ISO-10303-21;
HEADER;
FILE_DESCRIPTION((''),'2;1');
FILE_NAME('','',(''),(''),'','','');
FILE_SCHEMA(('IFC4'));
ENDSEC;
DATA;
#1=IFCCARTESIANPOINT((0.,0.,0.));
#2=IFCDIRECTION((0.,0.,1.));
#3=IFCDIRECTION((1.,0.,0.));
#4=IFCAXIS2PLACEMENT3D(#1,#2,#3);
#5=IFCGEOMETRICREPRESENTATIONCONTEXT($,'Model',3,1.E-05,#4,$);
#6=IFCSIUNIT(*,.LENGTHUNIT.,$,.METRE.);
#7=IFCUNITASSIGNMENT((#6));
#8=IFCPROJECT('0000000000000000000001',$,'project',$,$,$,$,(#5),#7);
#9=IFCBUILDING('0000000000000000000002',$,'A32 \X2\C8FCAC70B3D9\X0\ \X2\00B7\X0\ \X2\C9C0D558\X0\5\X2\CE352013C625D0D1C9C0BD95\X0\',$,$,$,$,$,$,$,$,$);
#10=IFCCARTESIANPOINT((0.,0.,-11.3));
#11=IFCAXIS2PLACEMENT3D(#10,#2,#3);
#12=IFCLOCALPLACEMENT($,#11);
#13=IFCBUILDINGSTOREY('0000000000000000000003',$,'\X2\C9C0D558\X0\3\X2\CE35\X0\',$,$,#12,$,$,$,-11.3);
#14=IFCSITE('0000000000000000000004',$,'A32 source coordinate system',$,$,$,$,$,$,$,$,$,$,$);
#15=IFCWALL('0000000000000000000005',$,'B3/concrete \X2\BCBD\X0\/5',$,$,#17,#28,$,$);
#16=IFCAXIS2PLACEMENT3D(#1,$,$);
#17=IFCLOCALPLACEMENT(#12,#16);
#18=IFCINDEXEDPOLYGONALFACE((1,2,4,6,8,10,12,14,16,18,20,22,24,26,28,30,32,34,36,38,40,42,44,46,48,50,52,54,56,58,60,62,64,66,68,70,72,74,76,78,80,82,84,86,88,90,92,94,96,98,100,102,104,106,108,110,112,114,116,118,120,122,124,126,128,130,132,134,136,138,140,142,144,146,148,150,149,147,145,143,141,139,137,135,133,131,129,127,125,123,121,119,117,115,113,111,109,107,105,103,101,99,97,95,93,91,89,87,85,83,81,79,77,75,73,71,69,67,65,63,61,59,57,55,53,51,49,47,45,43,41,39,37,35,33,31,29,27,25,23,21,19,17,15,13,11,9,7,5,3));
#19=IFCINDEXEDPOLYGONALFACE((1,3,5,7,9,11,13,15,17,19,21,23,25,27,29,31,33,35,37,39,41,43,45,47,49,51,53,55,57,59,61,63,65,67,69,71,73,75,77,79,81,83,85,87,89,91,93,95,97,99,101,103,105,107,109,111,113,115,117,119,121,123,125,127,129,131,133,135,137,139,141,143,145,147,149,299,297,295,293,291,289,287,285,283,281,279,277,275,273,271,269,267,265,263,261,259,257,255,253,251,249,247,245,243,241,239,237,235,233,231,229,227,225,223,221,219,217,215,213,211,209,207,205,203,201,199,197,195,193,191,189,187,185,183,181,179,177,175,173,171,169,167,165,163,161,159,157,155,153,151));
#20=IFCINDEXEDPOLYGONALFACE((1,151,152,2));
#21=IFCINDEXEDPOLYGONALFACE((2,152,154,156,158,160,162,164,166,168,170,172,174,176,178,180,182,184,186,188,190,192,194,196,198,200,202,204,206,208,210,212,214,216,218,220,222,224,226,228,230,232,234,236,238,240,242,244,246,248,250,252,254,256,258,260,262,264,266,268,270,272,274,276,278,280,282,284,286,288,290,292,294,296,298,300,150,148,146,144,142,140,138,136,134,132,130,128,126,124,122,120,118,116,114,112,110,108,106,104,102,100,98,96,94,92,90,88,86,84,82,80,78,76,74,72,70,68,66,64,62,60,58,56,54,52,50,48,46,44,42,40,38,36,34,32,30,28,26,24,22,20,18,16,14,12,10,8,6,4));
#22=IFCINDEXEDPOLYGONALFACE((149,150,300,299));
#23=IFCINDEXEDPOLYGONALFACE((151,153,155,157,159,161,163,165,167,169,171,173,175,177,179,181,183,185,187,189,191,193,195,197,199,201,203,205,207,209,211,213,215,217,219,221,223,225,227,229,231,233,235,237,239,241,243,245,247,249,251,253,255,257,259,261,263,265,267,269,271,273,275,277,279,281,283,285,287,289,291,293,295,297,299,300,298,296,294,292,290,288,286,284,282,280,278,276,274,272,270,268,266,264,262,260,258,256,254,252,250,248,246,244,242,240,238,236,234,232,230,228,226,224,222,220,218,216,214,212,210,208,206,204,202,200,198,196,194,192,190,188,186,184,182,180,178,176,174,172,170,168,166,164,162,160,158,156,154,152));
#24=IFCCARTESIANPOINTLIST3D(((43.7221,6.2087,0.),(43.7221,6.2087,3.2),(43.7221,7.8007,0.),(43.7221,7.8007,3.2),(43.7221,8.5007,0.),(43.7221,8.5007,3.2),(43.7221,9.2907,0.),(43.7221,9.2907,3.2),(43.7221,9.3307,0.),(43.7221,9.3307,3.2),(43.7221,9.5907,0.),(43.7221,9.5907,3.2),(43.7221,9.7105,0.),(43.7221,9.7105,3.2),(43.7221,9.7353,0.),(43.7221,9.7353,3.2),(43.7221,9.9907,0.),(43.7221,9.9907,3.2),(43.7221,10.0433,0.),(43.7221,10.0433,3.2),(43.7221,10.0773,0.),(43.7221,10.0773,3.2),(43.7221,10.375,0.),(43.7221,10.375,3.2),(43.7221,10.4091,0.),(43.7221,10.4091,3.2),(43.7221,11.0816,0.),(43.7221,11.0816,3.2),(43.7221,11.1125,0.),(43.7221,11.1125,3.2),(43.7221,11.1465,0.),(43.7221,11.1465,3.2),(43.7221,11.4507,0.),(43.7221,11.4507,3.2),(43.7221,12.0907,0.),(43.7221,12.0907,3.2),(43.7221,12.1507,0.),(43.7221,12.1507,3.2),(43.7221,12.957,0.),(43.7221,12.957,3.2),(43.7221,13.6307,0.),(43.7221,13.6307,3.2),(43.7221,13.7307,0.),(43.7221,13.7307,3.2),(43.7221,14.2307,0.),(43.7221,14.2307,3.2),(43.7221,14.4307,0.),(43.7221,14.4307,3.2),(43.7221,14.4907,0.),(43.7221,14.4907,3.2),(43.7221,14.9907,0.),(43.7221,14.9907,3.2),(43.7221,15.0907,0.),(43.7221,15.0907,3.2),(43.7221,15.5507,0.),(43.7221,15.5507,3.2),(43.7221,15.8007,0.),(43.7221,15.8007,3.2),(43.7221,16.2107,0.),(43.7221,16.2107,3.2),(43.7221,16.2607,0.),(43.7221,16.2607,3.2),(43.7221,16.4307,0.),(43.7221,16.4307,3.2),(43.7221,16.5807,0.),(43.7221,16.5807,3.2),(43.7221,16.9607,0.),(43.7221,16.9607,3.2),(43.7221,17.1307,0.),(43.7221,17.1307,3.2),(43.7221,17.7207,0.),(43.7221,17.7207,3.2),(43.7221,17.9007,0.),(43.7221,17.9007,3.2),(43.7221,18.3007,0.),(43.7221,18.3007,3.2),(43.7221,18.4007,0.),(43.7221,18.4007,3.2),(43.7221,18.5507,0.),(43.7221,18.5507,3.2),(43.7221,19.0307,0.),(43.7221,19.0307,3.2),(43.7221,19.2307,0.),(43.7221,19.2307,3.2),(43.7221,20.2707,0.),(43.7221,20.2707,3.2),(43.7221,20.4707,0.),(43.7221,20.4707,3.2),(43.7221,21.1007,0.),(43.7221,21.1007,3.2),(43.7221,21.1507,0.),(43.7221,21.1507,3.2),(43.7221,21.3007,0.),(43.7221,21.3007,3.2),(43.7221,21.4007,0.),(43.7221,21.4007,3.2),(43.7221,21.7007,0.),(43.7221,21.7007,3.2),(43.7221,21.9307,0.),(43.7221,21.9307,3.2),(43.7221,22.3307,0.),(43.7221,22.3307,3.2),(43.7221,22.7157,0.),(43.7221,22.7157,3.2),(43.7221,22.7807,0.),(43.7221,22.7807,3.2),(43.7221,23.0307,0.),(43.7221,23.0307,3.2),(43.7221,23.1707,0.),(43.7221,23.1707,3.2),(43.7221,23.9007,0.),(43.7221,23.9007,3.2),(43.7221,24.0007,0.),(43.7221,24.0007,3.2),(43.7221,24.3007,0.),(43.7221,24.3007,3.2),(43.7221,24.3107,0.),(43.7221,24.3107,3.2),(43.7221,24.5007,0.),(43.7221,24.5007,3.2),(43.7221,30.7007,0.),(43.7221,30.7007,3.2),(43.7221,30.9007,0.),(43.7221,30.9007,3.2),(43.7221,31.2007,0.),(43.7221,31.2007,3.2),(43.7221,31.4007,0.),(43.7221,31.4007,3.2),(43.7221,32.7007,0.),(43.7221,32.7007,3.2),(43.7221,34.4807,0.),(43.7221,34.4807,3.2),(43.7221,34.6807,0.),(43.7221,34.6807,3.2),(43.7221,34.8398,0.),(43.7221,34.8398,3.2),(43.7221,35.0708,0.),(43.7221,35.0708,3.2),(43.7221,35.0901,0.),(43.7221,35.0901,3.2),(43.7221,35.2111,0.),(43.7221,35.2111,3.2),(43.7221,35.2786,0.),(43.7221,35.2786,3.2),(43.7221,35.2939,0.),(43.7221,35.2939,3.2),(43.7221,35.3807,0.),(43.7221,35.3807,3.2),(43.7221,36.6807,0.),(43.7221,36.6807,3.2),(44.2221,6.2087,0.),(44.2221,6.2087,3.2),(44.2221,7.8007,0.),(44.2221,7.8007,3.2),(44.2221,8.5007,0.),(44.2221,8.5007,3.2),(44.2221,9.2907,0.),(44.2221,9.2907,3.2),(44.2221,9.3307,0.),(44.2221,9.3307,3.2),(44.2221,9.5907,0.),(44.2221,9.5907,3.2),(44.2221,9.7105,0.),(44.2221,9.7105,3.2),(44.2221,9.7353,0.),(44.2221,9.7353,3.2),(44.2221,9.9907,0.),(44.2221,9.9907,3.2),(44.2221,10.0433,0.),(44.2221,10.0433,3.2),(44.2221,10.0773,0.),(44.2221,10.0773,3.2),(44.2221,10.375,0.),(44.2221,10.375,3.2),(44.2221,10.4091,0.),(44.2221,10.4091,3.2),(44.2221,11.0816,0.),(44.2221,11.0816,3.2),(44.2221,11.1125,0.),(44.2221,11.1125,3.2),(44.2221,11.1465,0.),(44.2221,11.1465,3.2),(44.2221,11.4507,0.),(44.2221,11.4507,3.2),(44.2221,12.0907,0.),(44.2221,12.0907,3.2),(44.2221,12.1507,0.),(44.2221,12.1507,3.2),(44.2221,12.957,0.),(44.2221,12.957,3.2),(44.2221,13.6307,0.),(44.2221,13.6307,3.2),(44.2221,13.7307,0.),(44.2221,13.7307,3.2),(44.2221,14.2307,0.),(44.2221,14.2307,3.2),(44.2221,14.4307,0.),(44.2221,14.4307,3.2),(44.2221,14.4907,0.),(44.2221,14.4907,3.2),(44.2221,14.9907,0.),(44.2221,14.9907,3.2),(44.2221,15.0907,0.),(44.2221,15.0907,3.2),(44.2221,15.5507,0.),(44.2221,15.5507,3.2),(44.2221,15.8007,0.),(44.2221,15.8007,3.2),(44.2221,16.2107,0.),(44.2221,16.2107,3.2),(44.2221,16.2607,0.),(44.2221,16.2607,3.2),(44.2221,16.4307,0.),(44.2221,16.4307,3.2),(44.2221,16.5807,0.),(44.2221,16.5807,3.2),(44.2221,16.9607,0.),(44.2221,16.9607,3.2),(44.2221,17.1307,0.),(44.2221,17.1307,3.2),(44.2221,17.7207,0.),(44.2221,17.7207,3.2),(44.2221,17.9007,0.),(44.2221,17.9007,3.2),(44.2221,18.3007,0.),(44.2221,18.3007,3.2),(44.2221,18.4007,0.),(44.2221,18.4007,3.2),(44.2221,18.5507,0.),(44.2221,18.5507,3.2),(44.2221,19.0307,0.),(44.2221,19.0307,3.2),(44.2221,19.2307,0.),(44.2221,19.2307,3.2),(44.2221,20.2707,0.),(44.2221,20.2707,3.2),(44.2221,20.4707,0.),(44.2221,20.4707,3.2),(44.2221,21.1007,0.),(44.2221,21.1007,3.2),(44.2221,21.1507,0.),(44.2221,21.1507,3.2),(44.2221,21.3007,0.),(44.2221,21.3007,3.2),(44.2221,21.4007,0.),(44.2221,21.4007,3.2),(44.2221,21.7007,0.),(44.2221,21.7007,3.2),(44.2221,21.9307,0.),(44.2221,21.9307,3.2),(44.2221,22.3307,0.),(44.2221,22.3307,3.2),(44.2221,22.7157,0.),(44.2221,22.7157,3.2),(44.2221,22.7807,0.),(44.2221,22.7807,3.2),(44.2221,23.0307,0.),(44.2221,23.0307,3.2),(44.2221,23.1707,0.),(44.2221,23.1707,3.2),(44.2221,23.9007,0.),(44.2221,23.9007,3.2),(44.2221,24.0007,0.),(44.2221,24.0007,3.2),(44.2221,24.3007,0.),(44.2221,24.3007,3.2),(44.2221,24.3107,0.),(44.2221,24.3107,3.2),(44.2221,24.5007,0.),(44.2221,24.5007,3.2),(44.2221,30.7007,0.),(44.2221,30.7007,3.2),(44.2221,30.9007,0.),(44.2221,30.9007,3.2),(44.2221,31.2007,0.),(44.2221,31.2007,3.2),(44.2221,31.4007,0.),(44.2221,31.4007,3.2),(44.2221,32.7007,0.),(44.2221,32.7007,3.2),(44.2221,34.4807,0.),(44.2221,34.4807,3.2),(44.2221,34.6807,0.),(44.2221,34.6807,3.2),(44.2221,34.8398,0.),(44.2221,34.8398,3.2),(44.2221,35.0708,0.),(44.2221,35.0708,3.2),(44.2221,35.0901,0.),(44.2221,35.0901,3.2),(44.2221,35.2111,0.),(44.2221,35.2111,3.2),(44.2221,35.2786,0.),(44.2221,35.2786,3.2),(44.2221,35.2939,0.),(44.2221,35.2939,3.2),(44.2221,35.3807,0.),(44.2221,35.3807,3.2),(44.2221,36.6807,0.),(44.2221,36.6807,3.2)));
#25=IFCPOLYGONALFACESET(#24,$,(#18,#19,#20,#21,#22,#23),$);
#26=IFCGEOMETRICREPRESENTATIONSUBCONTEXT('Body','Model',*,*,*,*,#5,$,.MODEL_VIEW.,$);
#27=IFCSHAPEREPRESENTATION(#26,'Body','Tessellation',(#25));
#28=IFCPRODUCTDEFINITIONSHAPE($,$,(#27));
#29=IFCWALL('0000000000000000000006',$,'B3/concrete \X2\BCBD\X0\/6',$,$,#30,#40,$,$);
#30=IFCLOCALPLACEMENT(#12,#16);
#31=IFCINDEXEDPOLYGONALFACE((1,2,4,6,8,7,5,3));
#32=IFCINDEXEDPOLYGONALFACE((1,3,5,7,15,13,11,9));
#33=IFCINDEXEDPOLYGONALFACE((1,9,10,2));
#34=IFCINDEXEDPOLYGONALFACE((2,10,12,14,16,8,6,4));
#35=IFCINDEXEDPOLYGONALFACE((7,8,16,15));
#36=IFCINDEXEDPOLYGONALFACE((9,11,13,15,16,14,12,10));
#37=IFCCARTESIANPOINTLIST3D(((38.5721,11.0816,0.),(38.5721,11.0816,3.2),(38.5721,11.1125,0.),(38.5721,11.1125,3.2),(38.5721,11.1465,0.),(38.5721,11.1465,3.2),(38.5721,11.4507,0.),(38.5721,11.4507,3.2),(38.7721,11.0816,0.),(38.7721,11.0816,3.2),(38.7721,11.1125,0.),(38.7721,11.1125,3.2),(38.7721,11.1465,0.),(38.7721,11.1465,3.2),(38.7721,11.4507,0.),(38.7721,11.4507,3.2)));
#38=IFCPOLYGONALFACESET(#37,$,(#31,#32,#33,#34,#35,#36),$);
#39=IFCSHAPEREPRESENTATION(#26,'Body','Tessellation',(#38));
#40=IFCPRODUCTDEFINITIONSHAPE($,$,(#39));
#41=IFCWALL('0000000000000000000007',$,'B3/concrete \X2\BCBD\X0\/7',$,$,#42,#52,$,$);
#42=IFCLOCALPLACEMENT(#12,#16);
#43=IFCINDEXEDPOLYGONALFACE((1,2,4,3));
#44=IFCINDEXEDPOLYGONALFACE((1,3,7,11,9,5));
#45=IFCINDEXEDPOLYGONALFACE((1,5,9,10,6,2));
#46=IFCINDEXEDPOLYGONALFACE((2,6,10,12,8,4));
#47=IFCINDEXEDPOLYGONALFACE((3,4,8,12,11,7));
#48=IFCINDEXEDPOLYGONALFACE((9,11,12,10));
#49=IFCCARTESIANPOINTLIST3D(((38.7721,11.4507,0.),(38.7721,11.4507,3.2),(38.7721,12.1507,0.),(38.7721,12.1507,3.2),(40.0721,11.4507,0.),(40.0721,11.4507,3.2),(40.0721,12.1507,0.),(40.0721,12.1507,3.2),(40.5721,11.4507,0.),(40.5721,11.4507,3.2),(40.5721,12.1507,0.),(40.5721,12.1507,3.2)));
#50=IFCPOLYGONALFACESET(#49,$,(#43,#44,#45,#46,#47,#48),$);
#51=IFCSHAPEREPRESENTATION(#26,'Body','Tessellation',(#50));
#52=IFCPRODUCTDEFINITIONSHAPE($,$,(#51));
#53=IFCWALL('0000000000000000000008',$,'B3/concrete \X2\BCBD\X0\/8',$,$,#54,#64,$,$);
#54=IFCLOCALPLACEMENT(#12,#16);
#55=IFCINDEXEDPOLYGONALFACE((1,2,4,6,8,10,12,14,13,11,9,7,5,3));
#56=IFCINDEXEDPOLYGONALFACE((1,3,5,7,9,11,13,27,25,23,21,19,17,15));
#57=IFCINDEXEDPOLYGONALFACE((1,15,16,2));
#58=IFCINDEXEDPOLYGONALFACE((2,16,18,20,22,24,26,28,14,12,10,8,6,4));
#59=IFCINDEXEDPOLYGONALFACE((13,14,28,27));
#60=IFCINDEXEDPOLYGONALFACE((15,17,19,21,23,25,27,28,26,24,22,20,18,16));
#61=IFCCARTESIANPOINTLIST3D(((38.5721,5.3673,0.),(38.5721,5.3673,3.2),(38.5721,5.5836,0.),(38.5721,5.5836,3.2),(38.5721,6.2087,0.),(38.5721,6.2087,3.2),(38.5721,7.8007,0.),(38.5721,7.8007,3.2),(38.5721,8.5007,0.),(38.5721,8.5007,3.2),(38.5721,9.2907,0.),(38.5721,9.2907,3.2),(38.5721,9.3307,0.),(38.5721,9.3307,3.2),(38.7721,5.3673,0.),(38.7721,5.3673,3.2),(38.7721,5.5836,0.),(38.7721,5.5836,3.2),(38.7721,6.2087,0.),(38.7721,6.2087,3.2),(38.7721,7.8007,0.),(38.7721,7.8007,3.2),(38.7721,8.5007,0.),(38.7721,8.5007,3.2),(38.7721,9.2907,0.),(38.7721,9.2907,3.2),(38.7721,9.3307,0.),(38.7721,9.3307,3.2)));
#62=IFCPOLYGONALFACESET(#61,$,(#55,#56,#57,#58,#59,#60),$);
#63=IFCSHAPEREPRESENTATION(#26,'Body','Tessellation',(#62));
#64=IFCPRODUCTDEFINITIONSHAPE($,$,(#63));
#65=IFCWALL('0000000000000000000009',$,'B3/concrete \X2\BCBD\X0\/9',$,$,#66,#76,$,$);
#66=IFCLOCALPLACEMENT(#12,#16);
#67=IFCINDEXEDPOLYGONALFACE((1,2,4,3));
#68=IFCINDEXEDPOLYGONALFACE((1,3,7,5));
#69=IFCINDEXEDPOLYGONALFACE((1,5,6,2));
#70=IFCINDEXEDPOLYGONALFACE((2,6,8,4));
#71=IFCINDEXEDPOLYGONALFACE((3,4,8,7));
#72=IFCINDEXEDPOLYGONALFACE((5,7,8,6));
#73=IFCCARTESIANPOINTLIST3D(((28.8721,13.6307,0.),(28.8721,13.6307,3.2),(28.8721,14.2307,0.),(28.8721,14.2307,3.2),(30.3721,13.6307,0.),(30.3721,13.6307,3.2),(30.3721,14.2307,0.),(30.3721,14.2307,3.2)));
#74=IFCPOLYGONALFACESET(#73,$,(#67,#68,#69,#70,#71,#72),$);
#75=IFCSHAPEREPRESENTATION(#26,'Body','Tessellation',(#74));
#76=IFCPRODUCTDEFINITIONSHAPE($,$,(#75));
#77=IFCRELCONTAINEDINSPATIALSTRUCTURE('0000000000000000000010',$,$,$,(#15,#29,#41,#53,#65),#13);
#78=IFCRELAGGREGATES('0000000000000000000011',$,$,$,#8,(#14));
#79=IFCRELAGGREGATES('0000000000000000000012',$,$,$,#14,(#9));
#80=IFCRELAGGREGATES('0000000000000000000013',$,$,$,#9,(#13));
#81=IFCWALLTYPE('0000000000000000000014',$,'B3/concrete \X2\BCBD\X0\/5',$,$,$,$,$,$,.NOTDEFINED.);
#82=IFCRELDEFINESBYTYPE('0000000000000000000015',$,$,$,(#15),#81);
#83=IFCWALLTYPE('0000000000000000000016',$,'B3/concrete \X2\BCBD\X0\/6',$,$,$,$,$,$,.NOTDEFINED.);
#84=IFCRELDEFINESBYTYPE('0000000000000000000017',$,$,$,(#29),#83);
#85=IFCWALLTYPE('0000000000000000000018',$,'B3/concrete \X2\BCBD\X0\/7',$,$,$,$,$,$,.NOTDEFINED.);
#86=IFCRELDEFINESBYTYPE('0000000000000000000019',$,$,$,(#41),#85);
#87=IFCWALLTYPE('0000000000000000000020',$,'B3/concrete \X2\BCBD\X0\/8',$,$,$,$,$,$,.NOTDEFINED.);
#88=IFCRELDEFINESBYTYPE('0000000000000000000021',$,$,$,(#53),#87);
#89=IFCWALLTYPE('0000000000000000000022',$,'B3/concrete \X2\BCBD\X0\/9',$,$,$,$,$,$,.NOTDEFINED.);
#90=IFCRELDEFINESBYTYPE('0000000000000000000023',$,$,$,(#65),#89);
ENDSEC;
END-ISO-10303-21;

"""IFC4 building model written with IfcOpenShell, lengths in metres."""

from ifc_helpers import new_model, si_unit, frame, origin, origin_with_axes, place, context, subcontext, project, spatial, polyline, outline, extrude, source, transform, mapped, type_object, type_shapes, element, save


model = new_model("IFC4")

# Units and contexts
model_context = context("Model", 3, precision=1e-05, world=origin_with_axes())
body_context = subcontext(model_context, "Body", "Model", "MODEL_VIEW")
ifc_project = project(units=[si_unit("LENGTHUNIT", "METRE")], contexts=[model_context])

# Site, building, storey
site = spatial("IfcSite", under=ifc_project, Name="A32 source coordinate system")
building = spatial("IfcBuilding", under=site, Name="A32 주거동 · 지하5층–옥탑지붕")
storey_placement = place(None, frame((0.0, 0.0, -11.3), z_axis=(0.0, 0.0, 1.0), x_axis=(1.0, 0.0, 0.0)))
storey = spatial("IfcBuildingStorey", under=building, at=storey_placement, Name="지하3층", Elevation=-11.3)

# Walls
wall_type_1 = type_object("IfcWallType", Name="B3/concrete 벽/5", PredefinedType="NOTDEFINED")
shared_shape_1 = source(origin(), body_context, "Body", "SweptSolid", [
    extrude(outline(polyline([(44.2221, 35.2939), (44.2221, 35.2786), (44.2221, 35.2111), (44.2221, 35.0901), (44.2221, 35.0708), (44.2221, 34.8398), (44.2221, 34.6807), (44.2221, 34.4807), (44.2221, 32.7007), (44.2221, 31.4007), (44.2221, 31.2007), (44.2221, 30.9007), (44.2221, 30.7007), (44.2221, 24.5007), (44.2221, 24.3107), (44.2221, 24.3007), (44.2221, 24.0007), (44.2221, 23.9007), (44.2221, 23.1707), (44.2221, 23.0307), (44.2221, 22.7807), (44.2221, 22.7157), (44.2221, 22.3307), (44.2221, 21.9307), (44.2221, 21.7007), (44.2221, 21.4007), (44.2221, 21.3007), (44.2221, 21.1507), (44.2221, 21.1007), (44.2221, 20.4707), (44.2221, 20.2707), (44.2221, 19.2307), (44.2221, 19.0307), (44.2221, 18.5507), (44.2221, 18.4007), (44.2221, 18.3007), (44.2221, 17.9007), (44.2221, 17.7207), (44.2221, 17.1307), (44.2221, 16.9607), (44.2221, 16.5807), (44.2221, 16.4307), (44.2221, 16.2607), (44.2221, 16.2107), (44.2221, 15.8007), (44.2221, 15.5507), (44.2221, 15.0907), (44.2221, 14.9907), (44.2221, 14.4907), (44.2221, 14.4307), (44.2221, 14.2307), (44.2221, 13.7307), (44.2221, 13.6307), (44.2221, 12.957), (44.2221, 12.1507), (44.2221, 12.0907), (44.2221, 11.4507), (44.2221, 11.1465), (44.2221, 11.1125), (44.2221, 11.0816), (44.2221, 10.4091), (44.2221, 10.375), (44.2221, 10.0773), (44.2221, 10.0433), (44.2221, 9.9907), (44.2221, 9.7353), (44.2221, 9.7105), (44.2221, 9.5907), (44.2221, 9.3307), (44.2221, 9.2907), (44.2221, 8.5007), (44.2221, 7.8007), (44.2221, 6.2087), (43.7221, 6.2087), (43.7221, 7.8007), (43.7221, 8.5007), (43.7221, 9.2907), (43.7221, 9.3307), (43.7221, 9.5907), (43.7221, 9.7105), (43.7221, 9.7353), (43.7221, 9.9907), (43.7221, 10.0433), (43.7221, 10.0773), (43.7221, 10.375), (43.7221, 10.4091), (43.7221, 11.0816), (43.7221, 11.1125), (43.7221, 11.1465), (43.7221, 11.4507), (43.7221, 12.0907), (43.7221, 12.1507), (43.7221, 12.957), (43.7221, 13.6307), (43.7221, 13.7307), (43.7221, 14.2307), (43.7221, 14.4307), (43.7221, 14.4907), (43.7221, 14.9907), (43.7221, 15.0907), (43.7221, 15.5507), (43.7221, 15.8007), (43.7221, 16.2107), (43.7221, 16.2607), (43.7221, 16.4307), (43.7221, 16.5807), (43.7221, 16.9607), (43.7221, 17.1307), (43.7221, 17.7207), (43.7221, 17.9007), (43.7221, 18.3007), (43.7221, 18.4007), (43.7221, 18.5507), (43.7221, 19.0307), (43.7221, 19.2307), (43.7221, 20.2707), (43.7221, 20.4707), (43.7221, 21.1007), (43.7221, 21.1507), (43.7221, 21.3007), (43.7221, 21.4007), (43.7221, 21.7007), (43.7221, 21.9307), (43.7221, 22.3307), (43.7221, 22.7157), (43.7221, 22.7807), (43.7221, 23.0307), (43.7221, 23.1707), (43.7221, 23.9007), (43.7221, 24.0007), (43.7221, 24.3007), (43.7221, 24.3107), (43.7221, 24.5007), (43.7221, 30.7007), (43.7221, 30.9007), (43.7221, 31.2007), (43.7221, 31.4007), (43.7221, 32.7007), (43.7221, 34.4807), (43.7221, 34.6807), (43.7221, 34.8398), (43.7221, 35.0708), (43.7221, 35.0901), (43.7221, 35.2111), (43.7221, 35.2786), (43.7221, 35.2939), (43.7221, 35.3807), (43.7221, 36.6807), (44.2221, 36.6807), (44.2221, 35.3807), (44.2221, 35.2939)])), origin(), (0.0, 0.0, 1.0), 3.2),
])
type_shapes(wall_type_1, [shared_shape_1])
wall_1_placement = place(storey_placement, origin_with_axes())
element("IfcWall", 1, at=wall_1_placement, inside=storey, type_object=wall_type_1, Name="B3/concrete 벽/5", context=body_context, shape_type="MappedRepresentation", body=[
    mapped(shared_shape_1, transform((0.0, 0.0, 0.0), scale=1.0)),
])
wall_type_2 = type_object("IfcWallType", Name="B3/concrete 벽/6", PredefinedType="NOTDEFINED")
shared_shape_2 = source(origin(), body_context, "Body", "SweptSolid", [
    extrude(outline(polyline([(38.5721, 11.0816), (38.5721, 11.1125), (38.5721, 11.1465), (38.5721, 11.4507), (38.7721, 11.4507), (38.7721, 11.1465), (38.7721, 11.1125), (38.7721, 11.0816), (38.5721, 11.0816)])), origin(), (0.0, 0.0, 1.0), 3.2),
])
type_shapes(wall_type_2, [shared_shape_2])
wall_2_placement = place(storey_placement, origin_with_axes())
element("IfcWall", 2, at=wall_2_placement, inside=storey, type_object=wall_type_2, Name="B3/concrete 벽/6", context=body_context, shape_type="MappedRepresentation", body=[
    mapped(shared_shape_2, transform((0.0, 0.0, 0.0), scale=1.0)),
])
wall_type_3 = type_object("IfcWallType", Name="B3/concrete 벽/7", PredefinedType="NOTDEFINED")
shared_shape_3 = source(origin(), body_context, "Body", "SweptSolid", [
    extrude(outline(polyline([(40.5721, 12.1507), (40.5721, 11.4507), (40.0721, 11.4507), (38.7721, 11.4507), (38.7721, 12.1507), (40.0721, 12.1507), (40.5721, 12.1507)])), origin(), (0.0, 0.0, 1.0), 3.2),
])
type_shapes(wall_type_3, [shared_shape_3])
wall_3_placement = place(storey_placement, origin_with_axes())
element("IfcWall", 3, at=wall_3_placement, inside=storey, type_object=wall_type_3, Name="B3/concrete 벽/7", context=body_context, shape_type="MappedRepresentation", body=[
    mapped(shared_shape_3, transform((0.0, 0.0, 0.0), scale=1.0)),
])
wall_type_4 = type_object("IfcWallType", Name="B3/concrete 벽/8", PredefinedType="NOTDEFINED")
shared_shape_4 = source(origin(), body_context, "Body", "SweptSolid", [
    extrude(outline(polyline([(38.7721, 9.2907), (38.7721, 8.5007), (38.7721, 7.8007), (38.7721, 6.2087), (38.7721, 5.5836), (38.7721, 5.3673), (38.5721, 5.3673), (38.5721, 5.5836), (38.5721, 6.2087), (38.5721, 7.8007), (38.5721, 8.5007), (38.5721, 9.2907), (38.5721, 9.3307), (38.7721, 9.3307), (38.7721, 9.2907)])), origin(), (0.0, 0.0, 1.0), 3.2),
])
type_shapes(wall_type_4, [shared_shape_4])
wall_4_placement = place(storey_placement, origin_with_axes())
element("IfcWall", 4, at=wall_4_placement, inside=storey, type_object=wall_type_4, Name="B3/concrete 벽/8", context=body_context, shape_type="MappedRepresentation", body=[
    mapped(shared_shape_4, transform((0.0, 0.0, 0.0), scale=1.0)),
])
wall_type_5 = type_object("IfcWallType", Name="B3/concrete 벽/9", PredefinedType="NOTDEFINED")
shared_shape_5 = source(origin(), body_context, "Body", "SweptSolid", [
    extrude(outline(polyline([(28.8721, 13.6307), (28.8721, 14.2307), (30.3721, 14.2307), (30.3721, 13.6307), (28.8721, 13.6307)])), origin(), (0.0, 0.0, 1.0), 3.2),
])
type_shapes(wall_type_5, [shared_shape_5])
wall_5_placement = place(storey_placement, origin_with_axes())
element("IfcWall", 5, at=wall_5_placement, inside=storey, type_object=wall_type_5, Name="B3/concrete 벽/9", context=body_context, shape_type="MappedRepresentation", body=[
    mapped(shared_shape_5, transform((0.0, 0.0, 0.0), scale=1.0)),
])

save(model, "model.ifc")
